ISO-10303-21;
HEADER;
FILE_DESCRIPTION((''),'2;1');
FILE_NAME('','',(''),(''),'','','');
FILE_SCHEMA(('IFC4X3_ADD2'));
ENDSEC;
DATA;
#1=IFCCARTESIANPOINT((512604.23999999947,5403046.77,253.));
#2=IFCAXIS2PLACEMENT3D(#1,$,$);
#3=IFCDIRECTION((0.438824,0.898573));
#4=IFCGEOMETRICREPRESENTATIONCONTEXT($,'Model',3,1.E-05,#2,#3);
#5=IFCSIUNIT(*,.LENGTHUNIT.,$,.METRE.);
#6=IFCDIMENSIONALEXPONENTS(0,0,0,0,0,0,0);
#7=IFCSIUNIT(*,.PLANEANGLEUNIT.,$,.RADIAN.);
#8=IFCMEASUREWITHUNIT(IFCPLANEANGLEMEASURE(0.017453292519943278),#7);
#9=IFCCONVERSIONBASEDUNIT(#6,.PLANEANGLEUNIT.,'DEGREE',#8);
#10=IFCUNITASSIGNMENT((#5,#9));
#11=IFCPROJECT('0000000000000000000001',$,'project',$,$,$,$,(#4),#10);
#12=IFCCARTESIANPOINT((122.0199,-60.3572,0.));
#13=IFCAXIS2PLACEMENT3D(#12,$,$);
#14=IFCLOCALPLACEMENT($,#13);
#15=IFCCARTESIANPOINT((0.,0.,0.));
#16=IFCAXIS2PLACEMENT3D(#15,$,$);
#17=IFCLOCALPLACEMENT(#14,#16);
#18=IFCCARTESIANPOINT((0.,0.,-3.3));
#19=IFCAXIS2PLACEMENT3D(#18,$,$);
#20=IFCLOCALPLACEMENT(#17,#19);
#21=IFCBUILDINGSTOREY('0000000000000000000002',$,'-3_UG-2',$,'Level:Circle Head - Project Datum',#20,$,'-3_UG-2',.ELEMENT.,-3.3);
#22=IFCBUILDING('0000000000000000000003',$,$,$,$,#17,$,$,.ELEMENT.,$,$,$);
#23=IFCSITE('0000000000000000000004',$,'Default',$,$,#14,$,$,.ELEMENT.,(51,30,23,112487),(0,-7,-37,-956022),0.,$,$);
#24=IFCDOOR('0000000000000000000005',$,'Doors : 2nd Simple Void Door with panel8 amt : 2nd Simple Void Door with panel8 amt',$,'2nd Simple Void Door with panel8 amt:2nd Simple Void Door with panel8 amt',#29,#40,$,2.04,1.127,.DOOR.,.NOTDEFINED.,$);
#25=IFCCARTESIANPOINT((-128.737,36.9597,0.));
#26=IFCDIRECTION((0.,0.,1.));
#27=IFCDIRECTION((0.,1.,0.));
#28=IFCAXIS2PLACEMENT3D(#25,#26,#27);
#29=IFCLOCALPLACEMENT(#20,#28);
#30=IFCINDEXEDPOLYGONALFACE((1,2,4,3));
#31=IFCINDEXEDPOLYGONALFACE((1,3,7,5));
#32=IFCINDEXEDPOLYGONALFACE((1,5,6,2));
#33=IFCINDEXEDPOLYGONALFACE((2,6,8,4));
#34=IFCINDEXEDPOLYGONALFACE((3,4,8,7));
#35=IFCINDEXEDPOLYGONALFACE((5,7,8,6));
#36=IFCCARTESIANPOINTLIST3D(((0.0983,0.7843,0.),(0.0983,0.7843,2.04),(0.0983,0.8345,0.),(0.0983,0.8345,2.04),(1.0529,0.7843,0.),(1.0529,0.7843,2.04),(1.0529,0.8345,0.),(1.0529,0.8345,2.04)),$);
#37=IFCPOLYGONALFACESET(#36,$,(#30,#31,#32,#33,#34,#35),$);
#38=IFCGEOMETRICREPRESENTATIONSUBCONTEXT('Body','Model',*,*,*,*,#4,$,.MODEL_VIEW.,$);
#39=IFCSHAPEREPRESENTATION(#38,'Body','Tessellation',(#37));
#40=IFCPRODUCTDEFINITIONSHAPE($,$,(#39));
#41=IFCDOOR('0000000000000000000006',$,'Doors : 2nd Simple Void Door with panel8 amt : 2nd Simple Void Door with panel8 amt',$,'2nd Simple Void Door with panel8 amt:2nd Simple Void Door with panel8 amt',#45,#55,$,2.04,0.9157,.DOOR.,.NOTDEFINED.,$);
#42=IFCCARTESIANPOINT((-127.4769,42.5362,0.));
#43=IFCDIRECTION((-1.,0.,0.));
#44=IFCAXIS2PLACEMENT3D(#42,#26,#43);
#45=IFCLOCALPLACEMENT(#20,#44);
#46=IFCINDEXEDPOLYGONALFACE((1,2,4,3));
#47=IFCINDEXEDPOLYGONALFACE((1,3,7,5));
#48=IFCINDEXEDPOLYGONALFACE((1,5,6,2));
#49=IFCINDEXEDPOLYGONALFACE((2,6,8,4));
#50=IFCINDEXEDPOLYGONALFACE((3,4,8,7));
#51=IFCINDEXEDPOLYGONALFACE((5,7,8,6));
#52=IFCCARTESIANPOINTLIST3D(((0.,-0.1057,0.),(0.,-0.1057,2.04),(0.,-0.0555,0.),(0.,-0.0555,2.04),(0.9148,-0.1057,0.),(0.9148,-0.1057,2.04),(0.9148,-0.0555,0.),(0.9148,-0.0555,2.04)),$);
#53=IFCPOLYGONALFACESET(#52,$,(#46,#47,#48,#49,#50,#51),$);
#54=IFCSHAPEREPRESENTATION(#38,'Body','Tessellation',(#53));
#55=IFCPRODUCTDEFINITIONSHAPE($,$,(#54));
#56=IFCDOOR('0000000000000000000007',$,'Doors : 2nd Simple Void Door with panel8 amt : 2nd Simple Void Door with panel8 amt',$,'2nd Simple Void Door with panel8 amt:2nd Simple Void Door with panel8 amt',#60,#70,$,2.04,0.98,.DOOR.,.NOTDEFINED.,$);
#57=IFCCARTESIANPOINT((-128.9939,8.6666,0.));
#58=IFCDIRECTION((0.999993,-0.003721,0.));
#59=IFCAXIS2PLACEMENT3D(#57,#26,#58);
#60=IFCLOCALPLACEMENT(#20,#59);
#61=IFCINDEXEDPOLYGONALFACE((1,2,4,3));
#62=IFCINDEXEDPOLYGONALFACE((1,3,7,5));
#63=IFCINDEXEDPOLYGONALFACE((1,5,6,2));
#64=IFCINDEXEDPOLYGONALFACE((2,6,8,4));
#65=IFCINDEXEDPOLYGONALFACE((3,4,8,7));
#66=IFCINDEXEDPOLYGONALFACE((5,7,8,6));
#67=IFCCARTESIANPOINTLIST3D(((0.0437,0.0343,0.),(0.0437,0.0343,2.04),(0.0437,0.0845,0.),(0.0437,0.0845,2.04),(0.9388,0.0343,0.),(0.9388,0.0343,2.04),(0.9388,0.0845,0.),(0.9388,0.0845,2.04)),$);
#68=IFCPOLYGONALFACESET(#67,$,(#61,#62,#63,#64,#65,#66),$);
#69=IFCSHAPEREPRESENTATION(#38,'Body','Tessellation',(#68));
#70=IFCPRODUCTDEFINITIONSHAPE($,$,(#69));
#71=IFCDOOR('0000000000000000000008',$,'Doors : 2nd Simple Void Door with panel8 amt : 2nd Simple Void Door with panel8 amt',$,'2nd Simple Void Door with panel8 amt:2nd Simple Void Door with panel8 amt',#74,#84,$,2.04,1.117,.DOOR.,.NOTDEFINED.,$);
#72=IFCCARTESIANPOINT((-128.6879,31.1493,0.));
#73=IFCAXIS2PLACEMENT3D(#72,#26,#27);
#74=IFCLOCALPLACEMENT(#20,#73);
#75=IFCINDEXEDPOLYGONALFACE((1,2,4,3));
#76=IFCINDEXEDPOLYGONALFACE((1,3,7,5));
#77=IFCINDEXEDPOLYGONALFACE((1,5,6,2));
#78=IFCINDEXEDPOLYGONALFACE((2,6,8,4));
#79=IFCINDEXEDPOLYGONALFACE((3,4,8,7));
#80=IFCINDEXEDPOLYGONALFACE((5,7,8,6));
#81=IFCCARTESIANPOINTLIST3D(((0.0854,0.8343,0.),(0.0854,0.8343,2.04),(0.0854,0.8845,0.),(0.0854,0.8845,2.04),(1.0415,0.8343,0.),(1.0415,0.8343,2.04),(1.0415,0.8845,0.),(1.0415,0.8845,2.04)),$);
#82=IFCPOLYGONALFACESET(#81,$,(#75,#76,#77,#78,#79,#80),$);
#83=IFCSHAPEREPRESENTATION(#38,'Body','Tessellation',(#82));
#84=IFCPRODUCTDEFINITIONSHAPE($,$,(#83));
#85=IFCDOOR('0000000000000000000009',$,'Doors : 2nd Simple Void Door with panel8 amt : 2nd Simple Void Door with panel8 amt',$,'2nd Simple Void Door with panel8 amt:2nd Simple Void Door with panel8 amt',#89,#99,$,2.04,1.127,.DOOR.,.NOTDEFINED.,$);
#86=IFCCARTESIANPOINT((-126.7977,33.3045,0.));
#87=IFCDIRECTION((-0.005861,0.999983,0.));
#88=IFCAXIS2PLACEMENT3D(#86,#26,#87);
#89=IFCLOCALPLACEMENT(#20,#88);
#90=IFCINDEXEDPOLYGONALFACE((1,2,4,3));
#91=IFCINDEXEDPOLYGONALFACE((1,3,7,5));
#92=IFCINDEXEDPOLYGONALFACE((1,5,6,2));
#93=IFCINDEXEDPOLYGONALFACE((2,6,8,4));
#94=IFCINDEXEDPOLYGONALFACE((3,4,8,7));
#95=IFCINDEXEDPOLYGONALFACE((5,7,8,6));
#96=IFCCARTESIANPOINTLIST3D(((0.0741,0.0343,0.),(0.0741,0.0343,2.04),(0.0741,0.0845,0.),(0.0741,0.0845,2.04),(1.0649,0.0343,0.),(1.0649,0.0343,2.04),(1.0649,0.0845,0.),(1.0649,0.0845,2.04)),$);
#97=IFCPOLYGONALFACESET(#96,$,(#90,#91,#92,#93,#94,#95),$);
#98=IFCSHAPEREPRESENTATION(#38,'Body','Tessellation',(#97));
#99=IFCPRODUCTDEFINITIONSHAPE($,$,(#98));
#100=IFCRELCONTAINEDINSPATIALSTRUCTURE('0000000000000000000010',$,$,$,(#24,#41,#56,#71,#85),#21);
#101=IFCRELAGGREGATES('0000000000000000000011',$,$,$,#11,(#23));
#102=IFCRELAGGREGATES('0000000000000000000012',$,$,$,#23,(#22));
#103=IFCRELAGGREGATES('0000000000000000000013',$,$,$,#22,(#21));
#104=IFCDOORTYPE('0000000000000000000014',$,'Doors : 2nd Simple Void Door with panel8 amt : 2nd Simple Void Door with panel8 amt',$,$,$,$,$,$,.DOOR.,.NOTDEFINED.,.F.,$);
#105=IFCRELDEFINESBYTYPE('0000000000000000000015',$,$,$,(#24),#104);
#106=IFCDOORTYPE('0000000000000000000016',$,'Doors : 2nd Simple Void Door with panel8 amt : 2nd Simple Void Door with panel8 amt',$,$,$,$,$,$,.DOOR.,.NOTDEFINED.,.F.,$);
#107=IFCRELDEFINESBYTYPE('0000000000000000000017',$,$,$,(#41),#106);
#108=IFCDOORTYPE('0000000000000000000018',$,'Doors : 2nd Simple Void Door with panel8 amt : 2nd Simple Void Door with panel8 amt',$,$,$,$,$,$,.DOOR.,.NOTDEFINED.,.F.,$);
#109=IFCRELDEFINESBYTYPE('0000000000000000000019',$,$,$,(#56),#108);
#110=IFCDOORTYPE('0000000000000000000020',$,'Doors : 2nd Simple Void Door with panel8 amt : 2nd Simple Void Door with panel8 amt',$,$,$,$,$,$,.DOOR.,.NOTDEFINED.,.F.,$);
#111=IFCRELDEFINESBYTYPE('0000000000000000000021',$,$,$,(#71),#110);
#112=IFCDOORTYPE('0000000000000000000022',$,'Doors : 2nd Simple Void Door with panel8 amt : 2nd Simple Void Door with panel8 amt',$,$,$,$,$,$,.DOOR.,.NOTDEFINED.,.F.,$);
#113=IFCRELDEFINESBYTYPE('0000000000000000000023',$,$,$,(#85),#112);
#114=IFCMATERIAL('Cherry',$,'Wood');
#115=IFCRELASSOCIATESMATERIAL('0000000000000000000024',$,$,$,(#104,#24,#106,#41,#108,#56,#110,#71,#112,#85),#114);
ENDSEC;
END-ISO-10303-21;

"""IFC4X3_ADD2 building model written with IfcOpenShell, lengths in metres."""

from ifc_helpers import new_model, entity, si_unit, converted_unit, direction, frame, frame_2d, origin, origin_2d_with_axis, place, context, subcontext, project, spatial, rectangle, extrude, source, transform, mapped, material, type_object, type_shapes, element, save


model = new_model("IFC4X3_ADD2")

# Units and contexts
model_context = context("Model", 3, precision=1e-05, world=frame((512604.23999999947, 5403046.77, 253.0)), true_north=direction((0.438824, 0.898573)))
body_context = subcontext(model_context, "Body", "Model", "MODEL_VIEW")
ifc_project = project(units=[si_unit("LENGTHUNIT", "METRE"), converted_unit("PLANEANGLEUNIT", "DEGREE", entity("IfcPlaneAngleMeasure", 0.017453292519943278), si_unit("PLANEANGLEUNIT", "RADIAN"), dimensions=[0, 0, 0, 0, 0, 0, 0])], contexts=[model_context])

# Site, building, storey
site_placement = place(None, frame((122.0199, -60.3572, 0.0)))
site = spatial("IfcSite", under=ifc_project, at=site_placement, Name="Default", CompositionType="ELEMENT", RefLatitude=(51, 30, 23, 112487), RefLongitude=(0, -7, -37, -956022), RefElevation=0.0)
building_placement = place(site_placement, origin())
building = spatial("IfcBuilding", under=site, at=building_placement, CompositionType="ELEMENT")
storey_placement = place(building_placement, frame((0.0, 0.0, -3.3)))
storey = spatial("IfcBuildingStorey", under=building, at=storey_placement, Name="-3_UG-2", ObjectType="Level:Circle Head - Project Datum", LongName="-3_UG-2", CompositionType="ELEMENT", Elevation=-3.3)

# Shared definitions
ifc_material_1 = material(Name="Cherry", Category="Wood")

# Doors
door_type_1 = type_object("IfcDoorType", Name="Doors : 2nd Simple Void Door with panel8 amt : 2nd Simple Void Door with panel8 amt", OperationType="NOTDEFINED", ParameterTakesPrecedence=False, PredefinedType="DOOR", material=ifc_material_1)
shared_shape_1 = source(origin(), body_context, "Body", "SweptSolid", [
    extrude(rectangle(XDim=0.9545, YDim=0.0501, at=origin_2d_with_axis()), frame((0.5756, 0.8094, 0.0)), (0.0, 0.0, 1.0), 2.04),
])
type_shapes(door_type_1, [shared_shape_1])
door_1_placement = place(storey_placement, frame((-128.737, 36.9597, 0.0), z_axis=(0.0, 0.0, 1.0), x_axis=(0.0, 1.0, 0.0)))
element("IfcDoor", 1, at=door_1_placement, inside=storey, type_object=door_type_1, material=ifc_material_1, Name="Doors : 2nd Simple Void Door with panel8 amt : 2nd Simple Void Door with panel8 amt", ObjectType="2nd Simple Void Door with panel8 amt:2nd Simple Void Door with panel8 amt", OperationType="NOTDEFINED", OverallHeight=2.04, OverallWidth=1.127, PredefinedType="DOOR", context=body_context, shape_type="MappedRepresentation", body=[
    mapped(shared_shape_1, transform((0.0, 0.0, 0.0), scale=1.0)),
])
door_type_2 = type_object("IfcDoorType", Name="Doors : 2nd Simple Void Door with panel8 amt : 2nd Simple Void Door with panel8 amt", OperationType="NOTDEFINED", ParameterTakesPrecedence=False, PredefinedType="DOOR", material=ifc_material_1)
shared_shape_2 = source(origin(), body_context, "Body", "SweptSolid", [
    extrude(rectangle(XDim=0.0501, YDim=0.9148, at=origin_2d_with_axis()), frame((0.4574, -0.0806, 0.0), z_axis=(0.0, 0.0, 1.0), x_axis=(0.0, 1.0, 0.0)), (0.0, 0.0, 1.0), 2.04),
])
type_shapes(door_type_2, [shared_shape_2])
door_2_placement = place(storey_placement, frame((-127.4769, 42.5362, 0.0), z_axis=(0.0, 0.0, 1.0), x_axis=(-1.0, 0.0, 0.0)))
element("IfcDoor", 2, at=door_2_placement, inside=storey, type_object=door_type_2, material=ifc_material_1, Name="Doors : 2nd Simple Void Door with panel8 amt : 2nd Simple Void Door with panel8 amt", ObjectType="2nd Simple Void Door with panel8 amt:2nd Simple Void Door with panel8 amt", OperationType="NOTDEFINED", OverallHeight=2.04, OverallWidth=0.9157, PredefinedType="DOOR", context=body_context, shape_type="MappedRepresentation", body=[
    mapped(shared_shape_2, transform((0.0, 0.0, 0.0), scale=1.0)),
])
door_type_3 = type_object("IfcDoorType", Name="Doors : 2nd Simple Void Door with panel8 amt : 2nd Simple Void Door with panel8 amt", OperationType="NOTDEFINED", ParameterTakesPrecedence=False, PredefinedType="DOOR", material=ifc_material_1)
shared_shape_3 = source(origin(), body_context, "Body", "SweptSolid", [
    extrude(rectangle(XDim=0.0501, YDim=0.8951, at=frame_2d((0.0, 0.0), x_axis=(1.0, 0.0))), frame((0.4913, 0.0594, 0.0), z_axis=(0.0, 0.0, 1.0), x_axis=(0.0, 1.0, 0.0)), (0.0, 0.0, 1.0), 2.04),
])
type_shapes(door_type_3, [shared_shape_3])
door_3_placement = place(storey_placement, frame((-128.9939, 8.6666, 0.0), z_axis=(0.0, 0.0, 1.0), x_axis=(0.999993, -0.003721, 0.0)))
element("IfcDoor", 3, at=door_3_placement, inside=storey, type_object=door_type_3, material=ifc_material_1, Name="Doors : 2nd Simple Void Door with panel8 amt : 2nd Simple Void Door with panel8 amt", ObjectType="2nd Simple Void Door with panel8 amt:2nd Simple Void Door with panel8 amt", OperationType="NOTDEFINED", OverallHeight=2.04, OverallWidth=0.98, PredefinedType="DOOR", context=body_context, shape_type="MappedRepresentation", body=[
    mapped(shared_shape_3, transform((0.0, 0.0, 0.0), scale=1.0)),
])
door_type_4 = type_object("IfcDoorType", Name="Doors : 2nd Simple Void Door with panel8 amt : 2nd Simple Void Door with panel8 amt", OperationType="NOTDEFINED", ParameterTakesPrecedence=False, PredefinedType="DOOR", material=ifc_material_1)
shared_shape_4 = source(origin(), body_context, "Body", "SweptSolid", [
    extrude(rectangle(XDim=0.9561, YDim=0.0501, at=frame_2d((0.0, 0.0), x_axis=(1.0, 0.0))), frame((0.5635, 0.8594, 0.0)), (0.0, 0.0, 1.0), 2.04),
])
type_shapes(door_type_4, [shared_shape_4])
door_4_placement = place(storey_placement, frame((-128.6879, 31.1493, 0.0), z_axis=(0.0, 0.0, 1.0), x_axis=(0.0, 1.0, 0.0)))
element("IfcDoor", 4, at=door_4_placement, inside=storey, type_object=door_type_4, material=ifc_material_1, Name="Doors : 2nd Simple Void Door with panel8 amt : 2nd Simple Void Door with panel8 amt", ObjectType="2nd Simple Void Door with panel8 amt:2nd Simple Void Door with panel8 amt", OperationType="NOTDEFINED", OverallHeight=2.04, OverallWidth=1.117, PredefinedType="DOOR", context=body_context, shape_type="MappedRepresentation", body=[
    mapped(shared_shape_4, transform((0.0, 0.0, 0.0), scale=1.0)),
])
door_type_5 = type_object("IfcDoorType", Name="Doors : 2nd Simple Void Door with panel8 amt : 2nd Simple Void Door with panel8 amt", OperationType="NOTDEFINED", ParameterTakesPrecedence=False, PredefinedType="DOOR", material=ifc_material_1)
shared_shape_5 = source(origin(), body_context, "Body", "SweptSolid", [
    extrude(rectangle(XDim=0.0501, YDim=0.9908, at=frame_2d((0.0, 0.0), x_axis=(1.0, 0.0))), frame((0.5695, 0.0594, 0.0), z_axis=(0.0, 0.0, 1.0), x_axis=(0.0, 1.0, 0.0)), (0.0, 0.0, 1.0), 2.04),
])
type_shapes(door_type_5, [shared_shape_5])
door_5_placement = place(storey_placement, frame((-126.7977, 33.3045, 0.0), z_axis=(0.0, 0.0, 1.0), x_axis=(-0.005861, 0.999983, 0.0)))
element("IfcDoor", 5, at=door_5_placement, inside=storey, type_object=door_type_5, material=ifc_material_1, Name="Doors : 2nd Simple Void Door with panel8 amt : 2nd Simple Void Door with panel8 amt", ObjectType="2nd Simple Void Door with panel8 amt:2nd Simple Void Door with panel8 amt", OperationType="NOTDEFINED", OverallHeight=2.04, OverallWidth=1.127, PredefinedType="DOOR", context=body_context, shape_type="MappedRepresentation", body=[
    mapped(shared_shape_5, transform((0.0, 0.0, 0.0), scale=1.0)),
])

save(model, "model.ifc")
